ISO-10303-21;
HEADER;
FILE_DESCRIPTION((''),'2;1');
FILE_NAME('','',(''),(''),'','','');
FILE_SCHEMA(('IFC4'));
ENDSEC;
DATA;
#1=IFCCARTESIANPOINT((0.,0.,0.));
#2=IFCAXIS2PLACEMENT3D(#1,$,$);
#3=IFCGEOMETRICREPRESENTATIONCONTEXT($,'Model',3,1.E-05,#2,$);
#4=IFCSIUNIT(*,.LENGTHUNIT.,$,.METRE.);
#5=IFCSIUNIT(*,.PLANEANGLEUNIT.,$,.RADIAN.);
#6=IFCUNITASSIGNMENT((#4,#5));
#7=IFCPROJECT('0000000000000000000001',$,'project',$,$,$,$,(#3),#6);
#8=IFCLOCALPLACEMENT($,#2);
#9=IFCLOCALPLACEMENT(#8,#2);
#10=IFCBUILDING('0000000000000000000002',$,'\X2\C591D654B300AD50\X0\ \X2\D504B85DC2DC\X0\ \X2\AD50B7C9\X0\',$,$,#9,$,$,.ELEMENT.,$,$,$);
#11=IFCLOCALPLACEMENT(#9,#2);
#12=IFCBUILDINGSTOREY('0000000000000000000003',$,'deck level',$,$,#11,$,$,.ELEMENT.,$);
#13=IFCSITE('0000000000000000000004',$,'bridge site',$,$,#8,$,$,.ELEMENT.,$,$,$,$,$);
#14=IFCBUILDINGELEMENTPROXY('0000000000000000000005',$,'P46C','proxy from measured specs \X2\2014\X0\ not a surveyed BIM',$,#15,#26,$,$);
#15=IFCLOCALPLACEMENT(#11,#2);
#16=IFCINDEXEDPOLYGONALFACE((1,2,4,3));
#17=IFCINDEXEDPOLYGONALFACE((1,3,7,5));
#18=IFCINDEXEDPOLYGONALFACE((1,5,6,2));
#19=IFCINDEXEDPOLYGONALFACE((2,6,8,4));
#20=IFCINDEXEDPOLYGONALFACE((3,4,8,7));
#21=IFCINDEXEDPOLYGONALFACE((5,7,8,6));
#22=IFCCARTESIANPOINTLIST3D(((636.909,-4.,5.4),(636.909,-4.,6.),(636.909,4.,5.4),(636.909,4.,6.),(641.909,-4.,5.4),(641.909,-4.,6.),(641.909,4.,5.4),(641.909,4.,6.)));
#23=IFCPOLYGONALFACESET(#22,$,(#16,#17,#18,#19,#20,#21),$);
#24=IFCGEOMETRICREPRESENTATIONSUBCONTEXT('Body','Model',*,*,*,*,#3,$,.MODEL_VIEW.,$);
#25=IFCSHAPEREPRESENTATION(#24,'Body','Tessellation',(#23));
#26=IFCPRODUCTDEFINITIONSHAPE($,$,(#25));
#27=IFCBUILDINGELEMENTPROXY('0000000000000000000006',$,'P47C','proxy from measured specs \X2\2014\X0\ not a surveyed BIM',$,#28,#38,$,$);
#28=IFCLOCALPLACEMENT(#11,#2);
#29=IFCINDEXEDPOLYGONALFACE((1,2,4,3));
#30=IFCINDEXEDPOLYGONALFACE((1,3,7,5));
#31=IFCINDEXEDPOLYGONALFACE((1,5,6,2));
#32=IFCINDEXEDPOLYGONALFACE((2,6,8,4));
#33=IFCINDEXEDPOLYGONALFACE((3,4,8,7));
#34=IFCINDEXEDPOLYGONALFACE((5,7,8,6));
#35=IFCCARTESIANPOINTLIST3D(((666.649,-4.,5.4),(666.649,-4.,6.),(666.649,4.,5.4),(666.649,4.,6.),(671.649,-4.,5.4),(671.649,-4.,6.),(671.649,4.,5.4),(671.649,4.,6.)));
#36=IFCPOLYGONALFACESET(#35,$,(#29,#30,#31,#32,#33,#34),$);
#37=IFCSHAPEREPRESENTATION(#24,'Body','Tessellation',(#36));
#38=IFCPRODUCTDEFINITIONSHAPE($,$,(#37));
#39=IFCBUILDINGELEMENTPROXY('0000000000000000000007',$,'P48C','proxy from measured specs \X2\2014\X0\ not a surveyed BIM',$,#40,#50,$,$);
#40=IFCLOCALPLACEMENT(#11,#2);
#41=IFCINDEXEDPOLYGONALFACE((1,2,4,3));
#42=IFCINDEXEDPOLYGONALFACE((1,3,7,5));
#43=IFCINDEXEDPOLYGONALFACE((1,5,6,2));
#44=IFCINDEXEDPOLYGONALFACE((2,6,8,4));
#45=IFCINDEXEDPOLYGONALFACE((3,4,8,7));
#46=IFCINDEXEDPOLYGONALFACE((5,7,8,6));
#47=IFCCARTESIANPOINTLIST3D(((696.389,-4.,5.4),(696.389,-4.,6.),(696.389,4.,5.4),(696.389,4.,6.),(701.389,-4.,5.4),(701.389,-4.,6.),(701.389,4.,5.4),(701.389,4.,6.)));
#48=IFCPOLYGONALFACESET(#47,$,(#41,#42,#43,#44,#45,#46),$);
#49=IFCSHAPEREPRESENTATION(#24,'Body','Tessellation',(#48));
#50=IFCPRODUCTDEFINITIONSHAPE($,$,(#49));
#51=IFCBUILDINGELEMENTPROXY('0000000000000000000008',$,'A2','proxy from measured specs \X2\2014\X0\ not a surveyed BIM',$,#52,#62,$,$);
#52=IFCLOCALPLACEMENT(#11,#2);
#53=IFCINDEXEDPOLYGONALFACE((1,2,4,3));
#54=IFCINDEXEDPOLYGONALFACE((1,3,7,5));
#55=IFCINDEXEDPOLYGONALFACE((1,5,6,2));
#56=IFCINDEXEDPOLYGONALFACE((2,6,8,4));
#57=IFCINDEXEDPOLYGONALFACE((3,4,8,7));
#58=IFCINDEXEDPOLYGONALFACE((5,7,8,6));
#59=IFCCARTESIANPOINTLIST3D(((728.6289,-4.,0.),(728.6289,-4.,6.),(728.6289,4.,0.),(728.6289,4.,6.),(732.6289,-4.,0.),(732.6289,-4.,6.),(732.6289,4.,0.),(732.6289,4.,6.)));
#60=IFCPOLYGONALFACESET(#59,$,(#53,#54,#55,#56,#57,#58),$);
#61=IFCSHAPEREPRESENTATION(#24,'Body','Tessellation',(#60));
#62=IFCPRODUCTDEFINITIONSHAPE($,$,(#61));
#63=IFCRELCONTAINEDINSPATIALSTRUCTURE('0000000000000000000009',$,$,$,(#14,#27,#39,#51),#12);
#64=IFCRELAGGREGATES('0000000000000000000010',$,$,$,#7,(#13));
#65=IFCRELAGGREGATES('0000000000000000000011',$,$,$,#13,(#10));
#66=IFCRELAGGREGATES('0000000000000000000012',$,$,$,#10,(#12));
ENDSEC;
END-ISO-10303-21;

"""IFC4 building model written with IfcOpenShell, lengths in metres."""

from ifc_helpers import new_model, si_unit, frame, origin, origin_2d, place, context, subcontext, project, spatial, rectangle, extrude, element, save


model = new_model("IFC4")

# Units and contexts
model_context = context("Model", 3, precision=1e-05, world=origin())
body_context = subcontext(model_context, "Body", "Model", "MODEL_VIEW")
ifc_project = project(units=[si_unit("LENGTHUNIT", "METRE"), si_unit("PLANEANGLEUNIT", "RADIAN")], contexts=[model_context])

# Site, building, storey
site_placement = place(None, origin())
site = spatial("IfcSite", under=ifc_project, at=site_placement, Name="bridge site", CompositionType="ELEMENT")
building_placement = place(site_placement, origin())
building = spatial("IfcBuilding", under=site, at=building_placement, Name="양화대교 프록시 교량", CompositionType="ELEMENT")
storey_placement = place(building_placement, origin())
storey = spatial("IfcBuildingStorey", under=building, at=storey_placement, Name="deck level", CompositionType="ELEMENT")

# Building element proxies
for number, where, name in (
    (1, (639.409, 0.0, 5.4), "P46C"),
    (2, (669.149, 0.0, 5.4), "P47C"),
    (3, (698.889, 0.0, 5.4), "P48C"),
):
    element("IfcBuildingElementProxy", number, at=place(storey_placement, frame(where)), inside=storey, Name=name, Description="proxy from measured specs — not a surveyed BIM", context=body_context, shape_type="SweptSolid", body=[
        extrude(rectangle(XDim=5.0, YDim=8.0, at=origin_2d()), origin(), (0.0, 0.0, 1.0), 0.6),
    ])
proxy_placement = place(storey_placement, frame((730.6289, 0.0, 0.0)))
element("IfcBuildingElementProxy", 4, at=proxy_placement, inside=storey, Name="A2", Description="proxy from measured specs — not a surveyed BIM", context=body_context, shape_type="SweptSolid", body=[
    extrude(rectangle(XDim=4.0, YDim=8.0, at=origin_2d()), origin(), (0.0, 0.0, 1.0), 6.0),
])

save(model, "model.ifc")
